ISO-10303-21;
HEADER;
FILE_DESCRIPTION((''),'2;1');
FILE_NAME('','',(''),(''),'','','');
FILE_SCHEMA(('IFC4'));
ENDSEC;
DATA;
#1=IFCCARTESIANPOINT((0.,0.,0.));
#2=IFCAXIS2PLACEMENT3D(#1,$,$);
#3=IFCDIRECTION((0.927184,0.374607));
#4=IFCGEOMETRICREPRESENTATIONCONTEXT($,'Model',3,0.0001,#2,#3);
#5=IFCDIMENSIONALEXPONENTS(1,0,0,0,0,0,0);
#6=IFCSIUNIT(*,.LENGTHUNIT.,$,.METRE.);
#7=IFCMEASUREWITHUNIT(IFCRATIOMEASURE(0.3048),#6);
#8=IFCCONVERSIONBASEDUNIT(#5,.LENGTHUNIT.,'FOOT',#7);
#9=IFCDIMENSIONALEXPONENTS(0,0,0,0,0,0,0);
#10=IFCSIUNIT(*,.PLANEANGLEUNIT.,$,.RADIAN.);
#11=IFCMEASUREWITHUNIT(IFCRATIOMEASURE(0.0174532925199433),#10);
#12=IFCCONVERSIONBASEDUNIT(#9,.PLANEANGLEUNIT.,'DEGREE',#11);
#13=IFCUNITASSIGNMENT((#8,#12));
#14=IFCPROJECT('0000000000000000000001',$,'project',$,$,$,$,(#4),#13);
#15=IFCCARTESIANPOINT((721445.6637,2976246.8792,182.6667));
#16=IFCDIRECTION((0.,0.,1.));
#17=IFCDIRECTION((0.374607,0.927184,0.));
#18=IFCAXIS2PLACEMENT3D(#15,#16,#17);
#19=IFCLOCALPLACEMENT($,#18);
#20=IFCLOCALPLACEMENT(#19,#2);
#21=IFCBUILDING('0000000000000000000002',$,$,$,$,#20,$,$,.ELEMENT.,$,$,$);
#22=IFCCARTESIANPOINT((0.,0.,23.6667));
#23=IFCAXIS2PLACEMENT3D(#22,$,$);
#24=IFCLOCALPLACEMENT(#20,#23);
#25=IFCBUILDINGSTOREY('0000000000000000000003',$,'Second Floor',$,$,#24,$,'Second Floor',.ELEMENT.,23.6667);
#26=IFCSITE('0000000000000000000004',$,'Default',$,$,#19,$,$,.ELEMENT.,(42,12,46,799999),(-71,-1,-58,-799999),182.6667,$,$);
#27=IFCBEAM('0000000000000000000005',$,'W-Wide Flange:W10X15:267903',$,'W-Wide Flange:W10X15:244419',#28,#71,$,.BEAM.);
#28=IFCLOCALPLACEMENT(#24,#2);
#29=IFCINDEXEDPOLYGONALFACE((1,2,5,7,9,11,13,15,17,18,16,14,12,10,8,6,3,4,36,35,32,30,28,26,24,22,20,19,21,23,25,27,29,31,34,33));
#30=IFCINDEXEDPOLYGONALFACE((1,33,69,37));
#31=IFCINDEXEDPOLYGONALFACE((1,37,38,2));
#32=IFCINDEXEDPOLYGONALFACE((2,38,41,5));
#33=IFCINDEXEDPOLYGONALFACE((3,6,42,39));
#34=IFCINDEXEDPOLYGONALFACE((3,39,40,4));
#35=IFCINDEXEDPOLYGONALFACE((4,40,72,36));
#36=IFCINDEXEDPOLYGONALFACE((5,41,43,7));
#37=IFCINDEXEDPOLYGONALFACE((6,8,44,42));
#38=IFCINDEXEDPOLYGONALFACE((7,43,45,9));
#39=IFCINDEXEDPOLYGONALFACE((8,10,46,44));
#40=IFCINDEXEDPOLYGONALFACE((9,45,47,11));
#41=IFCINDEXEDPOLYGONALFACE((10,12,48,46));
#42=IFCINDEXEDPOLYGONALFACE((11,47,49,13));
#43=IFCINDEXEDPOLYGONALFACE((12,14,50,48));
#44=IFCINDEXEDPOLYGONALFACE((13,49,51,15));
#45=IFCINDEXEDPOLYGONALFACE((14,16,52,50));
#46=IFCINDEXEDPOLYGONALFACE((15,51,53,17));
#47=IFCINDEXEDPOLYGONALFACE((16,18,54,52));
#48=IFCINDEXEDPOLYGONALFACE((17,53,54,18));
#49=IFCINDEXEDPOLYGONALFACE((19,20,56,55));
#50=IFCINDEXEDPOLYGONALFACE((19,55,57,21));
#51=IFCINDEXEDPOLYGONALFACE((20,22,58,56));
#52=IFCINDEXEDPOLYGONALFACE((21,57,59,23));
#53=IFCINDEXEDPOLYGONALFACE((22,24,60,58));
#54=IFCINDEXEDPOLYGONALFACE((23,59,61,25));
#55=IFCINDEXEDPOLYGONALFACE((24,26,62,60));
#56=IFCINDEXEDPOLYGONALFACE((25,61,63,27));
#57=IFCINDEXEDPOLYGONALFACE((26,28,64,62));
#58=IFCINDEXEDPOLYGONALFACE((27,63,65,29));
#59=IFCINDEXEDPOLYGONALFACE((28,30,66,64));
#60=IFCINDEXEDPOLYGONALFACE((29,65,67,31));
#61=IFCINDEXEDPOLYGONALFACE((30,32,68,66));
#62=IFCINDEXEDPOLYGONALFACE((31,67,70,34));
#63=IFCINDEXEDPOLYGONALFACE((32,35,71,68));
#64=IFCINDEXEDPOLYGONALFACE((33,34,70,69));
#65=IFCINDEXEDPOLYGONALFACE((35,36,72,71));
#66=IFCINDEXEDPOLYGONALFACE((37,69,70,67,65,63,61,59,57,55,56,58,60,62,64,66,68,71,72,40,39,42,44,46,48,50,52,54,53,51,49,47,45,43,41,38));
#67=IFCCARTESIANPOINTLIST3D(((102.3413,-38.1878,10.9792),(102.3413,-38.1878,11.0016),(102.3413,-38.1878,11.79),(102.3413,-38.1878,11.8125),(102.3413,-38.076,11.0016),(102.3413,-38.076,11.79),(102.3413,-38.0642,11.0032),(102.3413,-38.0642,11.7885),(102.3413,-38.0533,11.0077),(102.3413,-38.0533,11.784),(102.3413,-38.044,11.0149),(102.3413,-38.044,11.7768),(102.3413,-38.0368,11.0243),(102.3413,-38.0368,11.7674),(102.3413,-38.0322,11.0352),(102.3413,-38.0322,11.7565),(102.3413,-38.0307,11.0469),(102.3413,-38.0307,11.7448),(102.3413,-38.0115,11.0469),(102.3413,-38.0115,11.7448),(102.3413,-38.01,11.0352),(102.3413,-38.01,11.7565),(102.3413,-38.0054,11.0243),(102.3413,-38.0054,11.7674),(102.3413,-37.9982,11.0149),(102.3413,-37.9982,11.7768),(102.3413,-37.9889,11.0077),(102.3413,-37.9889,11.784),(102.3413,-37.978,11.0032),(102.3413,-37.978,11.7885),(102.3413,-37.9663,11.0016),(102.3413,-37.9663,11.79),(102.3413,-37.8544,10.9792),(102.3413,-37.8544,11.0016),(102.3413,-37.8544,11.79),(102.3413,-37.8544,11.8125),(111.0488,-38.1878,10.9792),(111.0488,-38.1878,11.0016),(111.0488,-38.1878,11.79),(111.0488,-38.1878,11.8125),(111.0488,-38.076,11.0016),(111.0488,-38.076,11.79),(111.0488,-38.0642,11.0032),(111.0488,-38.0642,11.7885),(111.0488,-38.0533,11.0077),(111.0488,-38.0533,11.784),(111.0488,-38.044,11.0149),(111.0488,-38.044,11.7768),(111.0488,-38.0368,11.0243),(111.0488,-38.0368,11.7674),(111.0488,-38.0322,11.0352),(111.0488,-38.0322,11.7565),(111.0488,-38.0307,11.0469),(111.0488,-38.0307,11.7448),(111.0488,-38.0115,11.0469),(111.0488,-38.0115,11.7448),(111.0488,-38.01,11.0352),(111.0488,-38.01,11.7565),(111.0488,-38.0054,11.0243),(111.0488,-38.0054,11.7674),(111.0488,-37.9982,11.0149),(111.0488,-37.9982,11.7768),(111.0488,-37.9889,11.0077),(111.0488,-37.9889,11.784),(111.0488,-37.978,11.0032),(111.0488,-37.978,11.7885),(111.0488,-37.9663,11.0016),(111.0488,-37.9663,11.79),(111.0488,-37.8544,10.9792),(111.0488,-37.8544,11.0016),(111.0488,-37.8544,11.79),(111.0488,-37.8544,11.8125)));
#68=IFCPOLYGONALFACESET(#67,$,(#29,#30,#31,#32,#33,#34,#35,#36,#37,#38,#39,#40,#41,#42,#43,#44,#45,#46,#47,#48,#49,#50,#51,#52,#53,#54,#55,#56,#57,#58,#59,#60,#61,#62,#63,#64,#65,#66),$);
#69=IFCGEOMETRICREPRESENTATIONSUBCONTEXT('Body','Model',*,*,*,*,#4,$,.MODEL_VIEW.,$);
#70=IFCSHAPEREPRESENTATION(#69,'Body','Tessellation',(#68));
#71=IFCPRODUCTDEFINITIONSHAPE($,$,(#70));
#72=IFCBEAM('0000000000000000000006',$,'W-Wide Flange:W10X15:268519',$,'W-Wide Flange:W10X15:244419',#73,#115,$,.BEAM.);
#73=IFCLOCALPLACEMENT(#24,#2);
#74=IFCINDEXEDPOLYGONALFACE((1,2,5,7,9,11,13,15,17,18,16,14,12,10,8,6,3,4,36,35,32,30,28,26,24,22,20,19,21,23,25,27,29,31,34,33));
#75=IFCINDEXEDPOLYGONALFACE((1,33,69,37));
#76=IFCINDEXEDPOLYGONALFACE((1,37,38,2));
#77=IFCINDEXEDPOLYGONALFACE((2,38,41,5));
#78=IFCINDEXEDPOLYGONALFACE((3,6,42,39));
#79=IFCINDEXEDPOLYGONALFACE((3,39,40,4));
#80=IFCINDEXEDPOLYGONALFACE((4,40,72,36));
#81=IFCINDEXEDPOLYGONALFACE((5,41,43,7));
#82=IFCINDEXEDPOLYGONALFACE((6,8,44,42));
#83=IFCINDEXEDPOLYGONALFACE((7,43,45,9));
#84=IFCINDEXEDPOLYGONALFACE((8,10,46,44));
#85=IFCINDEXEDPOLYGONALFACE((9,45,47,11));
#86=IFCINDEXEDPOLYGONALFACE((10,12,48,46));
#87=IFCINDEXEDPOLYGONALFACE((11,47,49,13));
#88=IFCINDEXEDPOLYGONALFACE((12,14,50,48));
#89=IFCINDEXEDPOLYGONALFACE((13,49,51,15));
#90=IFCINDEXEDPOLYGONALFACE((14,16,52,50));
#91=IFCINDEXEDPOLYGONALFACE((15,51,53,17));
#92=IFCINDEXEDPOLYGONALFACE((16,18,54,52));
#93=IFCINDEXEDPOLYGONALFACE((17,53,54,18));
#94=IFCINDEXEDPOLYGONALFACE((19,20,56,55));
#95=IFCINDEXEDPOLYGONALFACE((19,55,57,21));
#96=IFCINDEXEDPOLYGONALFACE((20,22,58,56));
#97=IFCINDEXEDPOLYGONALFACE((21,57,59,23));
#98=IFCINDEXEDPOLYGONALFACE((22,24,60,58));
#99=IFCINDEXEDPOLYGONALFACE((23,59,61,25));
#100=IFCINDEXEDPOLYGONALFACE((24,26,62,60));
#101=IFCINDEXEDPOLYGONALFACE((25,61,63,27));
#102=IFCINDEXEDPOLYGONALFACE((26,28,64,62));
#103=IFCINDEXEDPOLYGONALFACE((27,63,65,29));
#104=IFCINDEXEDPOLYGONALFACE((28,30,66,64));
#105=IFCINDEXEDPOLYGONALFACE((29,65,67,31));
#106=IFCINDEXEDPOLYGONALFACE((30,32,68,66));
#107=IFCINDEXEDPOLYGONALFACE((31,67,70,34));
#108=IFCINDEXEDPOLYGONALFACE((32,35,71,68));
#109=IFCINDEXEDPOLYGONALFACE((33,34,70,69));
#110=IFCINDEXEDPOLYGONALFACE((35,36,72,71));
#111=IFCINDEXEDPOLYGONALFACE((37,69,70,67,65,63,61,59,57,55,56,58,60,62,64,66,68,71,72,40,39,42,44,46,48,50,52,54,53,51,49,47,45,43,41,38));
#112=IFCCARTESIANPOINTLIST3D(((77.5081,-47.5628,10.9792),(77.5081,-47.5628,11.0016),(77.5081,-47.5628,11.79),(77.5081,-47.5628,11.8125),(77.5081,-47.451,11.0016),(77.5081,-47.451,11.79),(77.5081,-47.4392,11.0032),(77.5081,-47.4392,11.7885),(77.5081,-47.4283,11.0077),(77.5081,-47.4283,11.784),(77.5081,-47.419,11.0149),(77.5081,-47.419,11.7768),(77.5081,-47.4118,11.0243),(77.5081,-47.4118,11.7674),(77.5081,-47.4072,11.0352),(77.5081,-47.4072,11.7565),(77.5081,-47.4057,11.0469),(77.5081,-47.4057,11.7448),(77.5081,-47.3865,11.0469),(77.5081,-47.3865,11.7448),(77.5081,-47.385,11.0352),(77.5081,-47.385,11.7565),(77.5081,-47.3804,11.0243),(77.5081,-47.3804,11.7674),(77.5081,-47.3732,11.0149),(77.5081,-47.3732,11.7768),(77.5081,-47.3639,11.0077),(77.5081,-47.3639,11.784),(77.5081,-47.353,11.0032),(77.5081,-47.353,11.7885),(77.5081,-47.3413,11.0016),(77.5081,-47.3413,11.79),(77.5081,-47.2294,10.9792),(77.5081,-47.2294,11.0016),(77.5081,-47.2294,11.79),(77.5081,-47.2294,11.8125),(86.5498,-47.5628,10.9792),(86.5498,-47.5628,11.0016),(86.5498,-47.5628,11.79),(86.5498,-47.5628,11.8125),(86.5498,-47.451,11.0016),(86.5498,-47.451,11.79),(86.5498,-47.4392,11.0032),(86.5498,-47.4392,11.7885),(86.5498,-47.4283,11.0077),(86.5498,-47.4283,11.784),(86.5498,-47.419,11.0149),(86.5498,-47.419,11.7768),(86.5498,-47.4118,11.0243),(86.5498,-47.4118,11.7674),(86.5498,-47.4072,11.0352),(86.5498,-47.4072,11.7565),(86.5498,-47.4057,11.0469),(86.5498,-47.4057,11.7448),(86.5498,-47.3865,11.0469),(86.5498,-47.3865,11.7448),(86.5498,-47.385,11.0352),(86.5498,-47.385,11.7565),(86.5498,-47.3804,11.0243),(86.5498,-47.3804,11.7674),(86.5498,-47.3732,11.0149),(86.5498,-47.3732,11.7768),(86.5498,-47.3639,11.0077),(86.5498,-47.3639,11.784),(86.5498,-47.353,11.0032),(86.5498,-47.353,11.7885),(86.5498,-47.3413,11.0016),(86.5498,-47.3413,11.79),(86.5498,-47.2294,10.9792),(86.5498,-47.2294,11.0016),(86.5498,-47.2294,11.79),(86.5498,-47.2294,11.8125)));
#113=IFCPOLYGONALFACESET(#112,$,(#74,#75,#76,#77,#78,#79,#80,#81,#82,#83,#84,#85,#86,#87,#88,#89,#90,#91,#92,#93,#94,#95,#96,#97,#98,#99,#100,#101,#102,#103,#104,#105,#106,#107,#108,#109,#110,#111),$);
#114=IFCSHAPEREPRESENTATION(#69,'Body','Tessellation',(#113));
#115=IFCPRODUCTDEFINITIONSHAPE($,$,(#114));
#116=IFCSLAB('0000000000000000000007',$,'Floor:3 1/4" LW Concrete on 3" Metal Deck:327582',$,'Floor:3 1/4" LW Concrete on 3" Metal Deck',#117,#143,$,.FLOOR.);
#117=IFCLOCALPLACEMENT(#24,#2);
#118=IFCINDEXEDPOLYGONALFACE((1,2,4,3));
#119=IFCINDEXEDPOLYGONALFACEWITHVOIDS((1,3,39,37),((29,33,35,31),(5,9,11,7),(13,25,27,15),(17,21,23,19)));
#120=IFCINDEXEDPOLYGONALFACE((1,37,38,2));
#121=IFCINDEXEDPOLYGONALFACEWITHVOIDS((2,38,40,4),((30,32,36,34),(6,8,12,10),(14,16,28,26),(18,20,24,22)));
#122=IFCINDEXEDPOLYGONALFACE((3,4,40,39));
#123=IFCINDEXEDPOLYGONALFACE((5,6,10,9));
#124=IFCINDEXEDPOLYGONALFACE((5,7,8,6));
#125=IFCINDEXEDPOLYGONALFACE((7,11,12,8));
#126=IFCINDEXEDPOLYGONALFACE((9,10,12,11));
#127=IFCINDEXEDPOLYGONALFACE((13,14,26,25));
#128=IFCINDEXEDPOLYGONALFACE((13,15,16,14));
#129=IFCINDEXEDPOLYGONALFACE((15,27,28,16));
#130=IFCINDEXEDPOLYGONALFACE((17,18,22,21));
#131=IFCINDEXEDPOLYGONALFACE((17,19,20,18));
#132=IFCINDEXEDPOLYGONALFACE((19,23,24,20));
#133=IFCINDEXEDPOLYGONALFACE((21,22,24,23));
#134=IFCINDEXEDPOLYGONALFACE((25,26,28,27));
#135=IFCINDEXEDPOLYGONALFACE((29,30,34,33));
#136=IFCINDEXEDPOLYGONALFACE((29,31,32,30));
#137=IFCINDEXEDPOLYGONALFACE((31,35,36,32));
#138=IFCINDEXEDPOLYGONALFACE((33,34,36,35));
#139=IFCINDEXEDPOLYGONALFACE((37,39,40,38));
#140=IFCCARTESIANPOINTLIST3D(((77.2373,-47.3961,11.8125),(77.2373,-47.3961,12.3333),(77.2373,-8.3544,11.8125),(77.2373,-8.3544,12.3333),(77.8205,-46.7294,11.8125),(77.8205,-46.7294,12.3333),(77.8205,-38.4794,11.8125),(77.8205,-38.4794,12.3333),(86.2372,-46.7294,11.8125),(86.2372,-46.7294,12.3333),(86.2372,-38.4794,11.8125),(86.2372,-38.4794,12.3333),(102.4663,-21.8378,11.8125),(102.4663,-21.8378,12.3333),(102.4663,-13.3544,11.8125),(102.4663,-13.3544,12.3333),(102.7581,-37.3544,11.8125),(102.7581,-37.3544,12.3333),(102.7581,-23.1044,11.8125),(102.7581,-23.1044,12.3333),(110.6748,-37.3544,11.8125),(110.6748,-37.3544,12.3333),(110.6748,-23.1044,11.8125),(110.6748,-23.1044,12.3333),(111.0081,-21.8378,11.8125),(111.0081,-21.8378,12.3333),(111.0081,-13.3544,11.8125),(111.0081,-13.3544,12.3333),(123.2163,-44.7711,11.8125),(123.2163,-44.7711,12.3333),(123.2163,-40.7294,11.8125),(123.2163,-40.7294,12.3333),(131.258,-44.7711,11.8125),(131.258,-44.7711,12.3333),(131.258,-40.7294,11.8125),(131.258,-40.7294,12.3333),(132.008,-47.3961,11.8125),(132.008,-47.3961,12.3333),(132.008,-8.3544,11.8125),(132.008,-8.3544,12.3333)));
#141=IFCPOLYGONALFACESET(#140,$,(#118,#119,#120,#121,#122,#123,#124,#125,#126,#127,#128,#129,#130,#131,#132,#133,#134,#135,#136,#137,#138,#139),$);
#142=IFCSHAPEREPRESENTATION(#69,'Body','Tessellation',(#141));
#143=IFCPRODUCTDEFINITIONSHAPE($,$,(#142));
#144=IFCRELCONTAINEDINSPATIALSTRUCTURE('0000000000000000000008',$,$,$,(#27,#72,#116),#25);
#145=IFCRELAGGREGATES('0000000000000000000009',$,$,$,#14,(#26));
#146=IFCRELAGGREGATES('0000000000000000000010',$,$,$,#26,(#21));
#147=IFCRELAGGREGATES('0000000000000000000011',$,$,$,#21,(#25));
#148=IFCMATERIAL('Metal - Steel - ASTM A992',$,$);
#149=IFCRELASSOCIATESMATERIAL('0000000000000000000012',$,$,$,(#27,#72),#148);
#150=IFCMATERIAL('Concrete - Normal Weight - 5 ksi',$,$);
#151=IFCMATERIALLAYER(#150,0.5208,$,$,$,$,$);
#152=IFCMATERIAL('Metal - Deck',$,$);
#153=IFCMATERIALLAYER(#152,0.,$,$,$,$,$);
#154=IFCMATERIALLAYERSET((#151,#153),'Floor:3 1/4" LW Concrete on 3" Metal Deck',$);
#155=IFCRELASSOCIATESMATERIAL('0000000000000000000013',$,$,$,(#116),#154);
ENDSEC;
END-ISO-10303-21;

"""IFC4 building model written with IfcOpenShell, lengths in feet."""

from ifc_helpers import new_model, entity, si_unit, converted_unit, direction, frame, frame_2d, origin, origin_2d_with_axis, place, context, subcontext, project, spatial, rectangle, i_section, extrude, material, layer, layer_set, layer_usage, element, save


model = new_model("IFC4")

# Units and contexts
model_context = context("Model", 3, precision=0.0001, world=origin(), true_north=direction((0.927184, 0.374607)))
body_context = subcontext(model_context, "Body", "Model", "MODEL_VIEW")
ifc_project = project(units=[converted_unit("LENGTHUNIT", "FOOT", entity("IfcRatioMeasure", 0.3048), si_unit("LENGTHUNIT", "METRE"), dimensions=[1, 0, 0, 0, 0, 0, 0]), converted_unit("PLANEANGLEUNIT", "DEGREE", entity("IfcRatioMeasure", 0.0174532925199433), si_unit("PLANEANGLEUNIT", "RADIAN"), dimensions=[0, 0, 0, 0, 0, 0, 0])], contexts=[model_context])

# Site, building, storey
site_placement = place(None, frame((721445.6637, 2976246.8792, 182.6667), z_axis=(0.0, 0.0, 1.0), x_axis=(0.374607, 0.927184, 0.0)))
site = spatial("IfcSite", under=ifc_project, at=site_placement, Name="Default", CompositionType="ELEMENT", RefLatitude=(42, 12, 46, 799999), RefLongitude=(-71, -1, -58, -799999), RefElevation=182.6667)
building_placement = place(site_placement, origin())
building = spatial("IfcBuilding", under=site, at=building_placement, CompositionType="ELEMENT")
storey_placement = place(building_placement, frame((0.0, 0.0, 23.6667)))
storey = spatial("IfcBuildingStorey", under=building, at=storey_placement, Name="Second Floor", LongName="Second Floor", CompositionType="ELEMENT", Elevation=23.6667)

# Shared definitions
ifc_material_1 = material(Name="Metal - Steel - ASTM A992")

# Beams
beam_1_placement = place(storey_placement, frame((102.008, -38.0211, 11.8125)))
element("IfcBeam", 1, at=beam_1_placement, inside=storey, material=ifc_material_1, Name="W-Wide Flange:W10X15:267903", ObjectType="W-Wide Flange:W10X15:244419", PredefinedType="BEAM", context=body_context, shape_type="SweptSolid", body=[
    extrude(i_section(OverallWidth=0.3333, OverallDepth=0.8333, WebThickness=0.0192, FlangeThickness=0.0225, FilletRadius=0.0452, at=frame_2d((0.0, 0.0), x_axis=(0.0, 1.0))), frame((0.3333, 0.0, -0.4167), z_axis=(1.0, 0.0, 0.0), x_axis=(0.0, 0.0, -1.0)), (0.0, 0.0, 1.0), 8.7075),
])
beam_2_placement = place(storey_placement, frame((77.2373, -47.3961, 11.8125)))
element("IfcBeam", 2, at=beam_2_placement, inside=storey, material=ifc_material_1, Name="W-Wide Flange:W10X15:268519", ObjectType="W-Wide Flange:W10X15:244419", PredefinedType="BEAM", context=body_context, shape_type="SweptSolid", body=[
    extrude(i_section(OverallWidth=0.3333, OverallDepth=0.8333, WebThickness=0.0192, FlangeThickness=0.0225, FilletRadius=0.0452, at=frame_2d((0.0, 0.0), x_axis=(0.0, 1.0))), frame((0.2708, 0.0, -0.4167), z_axis=(1.0, 0.0, 0.0), x_axis=(0.0, 0.0, -1.0)), (0.0, 0.0, 1.0), 9.0417),
])

# Slab, openings
ifc_material_2 = material(Name="Concrete - Normal Weight - 5 ksi")
ifc_layer_1 = layer(ifc_material_2, 0.5208)
ifc_material_3 = material(Name="Metal - Deck")
ifc_layer_2 = layer(ifc_material_3, 0.0)
ifc_layer_set = layer_set([ifc_layer_1, ifc_layer_2], Name="Floor:3 1/4\" LW Concrete on 3\" Metal Deck")
ifc_layer_usage = layer_usage(ifc_layer_set, "AXIS3", "POSITIVE", 0.0)
slab_placement = place(storey_placement, frame((77.2373, -47.3961, 11.8125)))
slab = element("IfcSlab", 3, at=slab_placement, inside=storey, material=ifc_layer_usage, Name="Floor:3 1/4\" LW Concrete on 3\" Metal Deck:327582", ObjectType="Floor:3 1/4\" LW Concrete on 3\" Metal Deck", PredefinedType="FLOOR", context=body_context, shape_type="SweptSolid", body=[
    extrude(rectangle(XDim=54.7707, YDim=39.0417, at=frame_2d((0.0, 0.0), x_axis=(-1.0, 0.0))), frame((27.3854, 19.5208, 0.5208), z_axis=(0.0, 0.0, -1.0), x_axis=(-1.0, 0.0, 0.0)), (0.0, 0.0, 1.0), 0.5208),
])
opening_1_placement = place(slab_placement, frame((29.4792, 17.1667, 0.5208)))
element("IfcOpeningElement", 4, at=opening_1_placement, cuts=slab, ObjectType="Opening", context=body_context, shape_type="SweptSolid", body=[
    extrude(rectangle(XDim=7.9167, YDim=14.25, at=origin_2d_with_axis()), frame((0.0, 0.0, 0.0), z_axis=(0.0, 0.0, -1.0), x_axis=(1.0, 0.0, 0.0)), (0.0, 0.0, 1.0), 0.5208),
])
opening_2_placement = place(slab_placement, frame((29.5, 29.8, 0.5208)))
element("IfcOpeningElement", 5, at=opening_2_placement, cuts=slab, ObjectType="Opening", context=body_context, shape_type="SweptSolid", body=[
    extrude(rectangle(XDim=8.5418, YDim=8.4834, at=origin_2d_with_axis()), frame((0.0, 0.0, 0.0), z_axis=(0.0, 0.0, -1.0), x_axis=(1.0, 0.0, 0.0)), (0.0, 0.0, 1.0), 0.5208),
])
opening_3_placement = place(slab_placement, frame((49.9999, 4.6458, 0.5208)))
element("IfcOpeningElement", 6, at=opening_3_placement, cuts=slab, ObjectType="Opening", context=body_context, shape_type="SweptSolid", body=[
    extrude(rectangle(XDim=8.0417, YDim=4.0417, at=origin_2d_with_axis()), frame((0.0, 0.0, 0.0), z_axis=(0.0, 0.0, -1.0), x_axis=(1.0, 0.0, 0.0)), (0.0, 0.0, 1.0), 0.5208),
])
opening_4_placement = place(slab_placement, frame((4.7916, 4.7917, 0.5208)))
element("IfcOpeningElement", 7, at=opening_4_placement, cuts=slab, ObjectType="Opening", context=body_context, shape_type="SweptSolid", body=[
    extrude(rectangle(XDim=8.4167, YDim=8.25, at=origin_2d_with_axis()), frame((0.0, 0.0, 0.0), z_axis=(0.0, 0.0, -1.0), x_axis=(1.0, 0.0, 0.0)), (0.0, 0.0, 1.0), 0.5208),
])

save(model, "model.ifc")
